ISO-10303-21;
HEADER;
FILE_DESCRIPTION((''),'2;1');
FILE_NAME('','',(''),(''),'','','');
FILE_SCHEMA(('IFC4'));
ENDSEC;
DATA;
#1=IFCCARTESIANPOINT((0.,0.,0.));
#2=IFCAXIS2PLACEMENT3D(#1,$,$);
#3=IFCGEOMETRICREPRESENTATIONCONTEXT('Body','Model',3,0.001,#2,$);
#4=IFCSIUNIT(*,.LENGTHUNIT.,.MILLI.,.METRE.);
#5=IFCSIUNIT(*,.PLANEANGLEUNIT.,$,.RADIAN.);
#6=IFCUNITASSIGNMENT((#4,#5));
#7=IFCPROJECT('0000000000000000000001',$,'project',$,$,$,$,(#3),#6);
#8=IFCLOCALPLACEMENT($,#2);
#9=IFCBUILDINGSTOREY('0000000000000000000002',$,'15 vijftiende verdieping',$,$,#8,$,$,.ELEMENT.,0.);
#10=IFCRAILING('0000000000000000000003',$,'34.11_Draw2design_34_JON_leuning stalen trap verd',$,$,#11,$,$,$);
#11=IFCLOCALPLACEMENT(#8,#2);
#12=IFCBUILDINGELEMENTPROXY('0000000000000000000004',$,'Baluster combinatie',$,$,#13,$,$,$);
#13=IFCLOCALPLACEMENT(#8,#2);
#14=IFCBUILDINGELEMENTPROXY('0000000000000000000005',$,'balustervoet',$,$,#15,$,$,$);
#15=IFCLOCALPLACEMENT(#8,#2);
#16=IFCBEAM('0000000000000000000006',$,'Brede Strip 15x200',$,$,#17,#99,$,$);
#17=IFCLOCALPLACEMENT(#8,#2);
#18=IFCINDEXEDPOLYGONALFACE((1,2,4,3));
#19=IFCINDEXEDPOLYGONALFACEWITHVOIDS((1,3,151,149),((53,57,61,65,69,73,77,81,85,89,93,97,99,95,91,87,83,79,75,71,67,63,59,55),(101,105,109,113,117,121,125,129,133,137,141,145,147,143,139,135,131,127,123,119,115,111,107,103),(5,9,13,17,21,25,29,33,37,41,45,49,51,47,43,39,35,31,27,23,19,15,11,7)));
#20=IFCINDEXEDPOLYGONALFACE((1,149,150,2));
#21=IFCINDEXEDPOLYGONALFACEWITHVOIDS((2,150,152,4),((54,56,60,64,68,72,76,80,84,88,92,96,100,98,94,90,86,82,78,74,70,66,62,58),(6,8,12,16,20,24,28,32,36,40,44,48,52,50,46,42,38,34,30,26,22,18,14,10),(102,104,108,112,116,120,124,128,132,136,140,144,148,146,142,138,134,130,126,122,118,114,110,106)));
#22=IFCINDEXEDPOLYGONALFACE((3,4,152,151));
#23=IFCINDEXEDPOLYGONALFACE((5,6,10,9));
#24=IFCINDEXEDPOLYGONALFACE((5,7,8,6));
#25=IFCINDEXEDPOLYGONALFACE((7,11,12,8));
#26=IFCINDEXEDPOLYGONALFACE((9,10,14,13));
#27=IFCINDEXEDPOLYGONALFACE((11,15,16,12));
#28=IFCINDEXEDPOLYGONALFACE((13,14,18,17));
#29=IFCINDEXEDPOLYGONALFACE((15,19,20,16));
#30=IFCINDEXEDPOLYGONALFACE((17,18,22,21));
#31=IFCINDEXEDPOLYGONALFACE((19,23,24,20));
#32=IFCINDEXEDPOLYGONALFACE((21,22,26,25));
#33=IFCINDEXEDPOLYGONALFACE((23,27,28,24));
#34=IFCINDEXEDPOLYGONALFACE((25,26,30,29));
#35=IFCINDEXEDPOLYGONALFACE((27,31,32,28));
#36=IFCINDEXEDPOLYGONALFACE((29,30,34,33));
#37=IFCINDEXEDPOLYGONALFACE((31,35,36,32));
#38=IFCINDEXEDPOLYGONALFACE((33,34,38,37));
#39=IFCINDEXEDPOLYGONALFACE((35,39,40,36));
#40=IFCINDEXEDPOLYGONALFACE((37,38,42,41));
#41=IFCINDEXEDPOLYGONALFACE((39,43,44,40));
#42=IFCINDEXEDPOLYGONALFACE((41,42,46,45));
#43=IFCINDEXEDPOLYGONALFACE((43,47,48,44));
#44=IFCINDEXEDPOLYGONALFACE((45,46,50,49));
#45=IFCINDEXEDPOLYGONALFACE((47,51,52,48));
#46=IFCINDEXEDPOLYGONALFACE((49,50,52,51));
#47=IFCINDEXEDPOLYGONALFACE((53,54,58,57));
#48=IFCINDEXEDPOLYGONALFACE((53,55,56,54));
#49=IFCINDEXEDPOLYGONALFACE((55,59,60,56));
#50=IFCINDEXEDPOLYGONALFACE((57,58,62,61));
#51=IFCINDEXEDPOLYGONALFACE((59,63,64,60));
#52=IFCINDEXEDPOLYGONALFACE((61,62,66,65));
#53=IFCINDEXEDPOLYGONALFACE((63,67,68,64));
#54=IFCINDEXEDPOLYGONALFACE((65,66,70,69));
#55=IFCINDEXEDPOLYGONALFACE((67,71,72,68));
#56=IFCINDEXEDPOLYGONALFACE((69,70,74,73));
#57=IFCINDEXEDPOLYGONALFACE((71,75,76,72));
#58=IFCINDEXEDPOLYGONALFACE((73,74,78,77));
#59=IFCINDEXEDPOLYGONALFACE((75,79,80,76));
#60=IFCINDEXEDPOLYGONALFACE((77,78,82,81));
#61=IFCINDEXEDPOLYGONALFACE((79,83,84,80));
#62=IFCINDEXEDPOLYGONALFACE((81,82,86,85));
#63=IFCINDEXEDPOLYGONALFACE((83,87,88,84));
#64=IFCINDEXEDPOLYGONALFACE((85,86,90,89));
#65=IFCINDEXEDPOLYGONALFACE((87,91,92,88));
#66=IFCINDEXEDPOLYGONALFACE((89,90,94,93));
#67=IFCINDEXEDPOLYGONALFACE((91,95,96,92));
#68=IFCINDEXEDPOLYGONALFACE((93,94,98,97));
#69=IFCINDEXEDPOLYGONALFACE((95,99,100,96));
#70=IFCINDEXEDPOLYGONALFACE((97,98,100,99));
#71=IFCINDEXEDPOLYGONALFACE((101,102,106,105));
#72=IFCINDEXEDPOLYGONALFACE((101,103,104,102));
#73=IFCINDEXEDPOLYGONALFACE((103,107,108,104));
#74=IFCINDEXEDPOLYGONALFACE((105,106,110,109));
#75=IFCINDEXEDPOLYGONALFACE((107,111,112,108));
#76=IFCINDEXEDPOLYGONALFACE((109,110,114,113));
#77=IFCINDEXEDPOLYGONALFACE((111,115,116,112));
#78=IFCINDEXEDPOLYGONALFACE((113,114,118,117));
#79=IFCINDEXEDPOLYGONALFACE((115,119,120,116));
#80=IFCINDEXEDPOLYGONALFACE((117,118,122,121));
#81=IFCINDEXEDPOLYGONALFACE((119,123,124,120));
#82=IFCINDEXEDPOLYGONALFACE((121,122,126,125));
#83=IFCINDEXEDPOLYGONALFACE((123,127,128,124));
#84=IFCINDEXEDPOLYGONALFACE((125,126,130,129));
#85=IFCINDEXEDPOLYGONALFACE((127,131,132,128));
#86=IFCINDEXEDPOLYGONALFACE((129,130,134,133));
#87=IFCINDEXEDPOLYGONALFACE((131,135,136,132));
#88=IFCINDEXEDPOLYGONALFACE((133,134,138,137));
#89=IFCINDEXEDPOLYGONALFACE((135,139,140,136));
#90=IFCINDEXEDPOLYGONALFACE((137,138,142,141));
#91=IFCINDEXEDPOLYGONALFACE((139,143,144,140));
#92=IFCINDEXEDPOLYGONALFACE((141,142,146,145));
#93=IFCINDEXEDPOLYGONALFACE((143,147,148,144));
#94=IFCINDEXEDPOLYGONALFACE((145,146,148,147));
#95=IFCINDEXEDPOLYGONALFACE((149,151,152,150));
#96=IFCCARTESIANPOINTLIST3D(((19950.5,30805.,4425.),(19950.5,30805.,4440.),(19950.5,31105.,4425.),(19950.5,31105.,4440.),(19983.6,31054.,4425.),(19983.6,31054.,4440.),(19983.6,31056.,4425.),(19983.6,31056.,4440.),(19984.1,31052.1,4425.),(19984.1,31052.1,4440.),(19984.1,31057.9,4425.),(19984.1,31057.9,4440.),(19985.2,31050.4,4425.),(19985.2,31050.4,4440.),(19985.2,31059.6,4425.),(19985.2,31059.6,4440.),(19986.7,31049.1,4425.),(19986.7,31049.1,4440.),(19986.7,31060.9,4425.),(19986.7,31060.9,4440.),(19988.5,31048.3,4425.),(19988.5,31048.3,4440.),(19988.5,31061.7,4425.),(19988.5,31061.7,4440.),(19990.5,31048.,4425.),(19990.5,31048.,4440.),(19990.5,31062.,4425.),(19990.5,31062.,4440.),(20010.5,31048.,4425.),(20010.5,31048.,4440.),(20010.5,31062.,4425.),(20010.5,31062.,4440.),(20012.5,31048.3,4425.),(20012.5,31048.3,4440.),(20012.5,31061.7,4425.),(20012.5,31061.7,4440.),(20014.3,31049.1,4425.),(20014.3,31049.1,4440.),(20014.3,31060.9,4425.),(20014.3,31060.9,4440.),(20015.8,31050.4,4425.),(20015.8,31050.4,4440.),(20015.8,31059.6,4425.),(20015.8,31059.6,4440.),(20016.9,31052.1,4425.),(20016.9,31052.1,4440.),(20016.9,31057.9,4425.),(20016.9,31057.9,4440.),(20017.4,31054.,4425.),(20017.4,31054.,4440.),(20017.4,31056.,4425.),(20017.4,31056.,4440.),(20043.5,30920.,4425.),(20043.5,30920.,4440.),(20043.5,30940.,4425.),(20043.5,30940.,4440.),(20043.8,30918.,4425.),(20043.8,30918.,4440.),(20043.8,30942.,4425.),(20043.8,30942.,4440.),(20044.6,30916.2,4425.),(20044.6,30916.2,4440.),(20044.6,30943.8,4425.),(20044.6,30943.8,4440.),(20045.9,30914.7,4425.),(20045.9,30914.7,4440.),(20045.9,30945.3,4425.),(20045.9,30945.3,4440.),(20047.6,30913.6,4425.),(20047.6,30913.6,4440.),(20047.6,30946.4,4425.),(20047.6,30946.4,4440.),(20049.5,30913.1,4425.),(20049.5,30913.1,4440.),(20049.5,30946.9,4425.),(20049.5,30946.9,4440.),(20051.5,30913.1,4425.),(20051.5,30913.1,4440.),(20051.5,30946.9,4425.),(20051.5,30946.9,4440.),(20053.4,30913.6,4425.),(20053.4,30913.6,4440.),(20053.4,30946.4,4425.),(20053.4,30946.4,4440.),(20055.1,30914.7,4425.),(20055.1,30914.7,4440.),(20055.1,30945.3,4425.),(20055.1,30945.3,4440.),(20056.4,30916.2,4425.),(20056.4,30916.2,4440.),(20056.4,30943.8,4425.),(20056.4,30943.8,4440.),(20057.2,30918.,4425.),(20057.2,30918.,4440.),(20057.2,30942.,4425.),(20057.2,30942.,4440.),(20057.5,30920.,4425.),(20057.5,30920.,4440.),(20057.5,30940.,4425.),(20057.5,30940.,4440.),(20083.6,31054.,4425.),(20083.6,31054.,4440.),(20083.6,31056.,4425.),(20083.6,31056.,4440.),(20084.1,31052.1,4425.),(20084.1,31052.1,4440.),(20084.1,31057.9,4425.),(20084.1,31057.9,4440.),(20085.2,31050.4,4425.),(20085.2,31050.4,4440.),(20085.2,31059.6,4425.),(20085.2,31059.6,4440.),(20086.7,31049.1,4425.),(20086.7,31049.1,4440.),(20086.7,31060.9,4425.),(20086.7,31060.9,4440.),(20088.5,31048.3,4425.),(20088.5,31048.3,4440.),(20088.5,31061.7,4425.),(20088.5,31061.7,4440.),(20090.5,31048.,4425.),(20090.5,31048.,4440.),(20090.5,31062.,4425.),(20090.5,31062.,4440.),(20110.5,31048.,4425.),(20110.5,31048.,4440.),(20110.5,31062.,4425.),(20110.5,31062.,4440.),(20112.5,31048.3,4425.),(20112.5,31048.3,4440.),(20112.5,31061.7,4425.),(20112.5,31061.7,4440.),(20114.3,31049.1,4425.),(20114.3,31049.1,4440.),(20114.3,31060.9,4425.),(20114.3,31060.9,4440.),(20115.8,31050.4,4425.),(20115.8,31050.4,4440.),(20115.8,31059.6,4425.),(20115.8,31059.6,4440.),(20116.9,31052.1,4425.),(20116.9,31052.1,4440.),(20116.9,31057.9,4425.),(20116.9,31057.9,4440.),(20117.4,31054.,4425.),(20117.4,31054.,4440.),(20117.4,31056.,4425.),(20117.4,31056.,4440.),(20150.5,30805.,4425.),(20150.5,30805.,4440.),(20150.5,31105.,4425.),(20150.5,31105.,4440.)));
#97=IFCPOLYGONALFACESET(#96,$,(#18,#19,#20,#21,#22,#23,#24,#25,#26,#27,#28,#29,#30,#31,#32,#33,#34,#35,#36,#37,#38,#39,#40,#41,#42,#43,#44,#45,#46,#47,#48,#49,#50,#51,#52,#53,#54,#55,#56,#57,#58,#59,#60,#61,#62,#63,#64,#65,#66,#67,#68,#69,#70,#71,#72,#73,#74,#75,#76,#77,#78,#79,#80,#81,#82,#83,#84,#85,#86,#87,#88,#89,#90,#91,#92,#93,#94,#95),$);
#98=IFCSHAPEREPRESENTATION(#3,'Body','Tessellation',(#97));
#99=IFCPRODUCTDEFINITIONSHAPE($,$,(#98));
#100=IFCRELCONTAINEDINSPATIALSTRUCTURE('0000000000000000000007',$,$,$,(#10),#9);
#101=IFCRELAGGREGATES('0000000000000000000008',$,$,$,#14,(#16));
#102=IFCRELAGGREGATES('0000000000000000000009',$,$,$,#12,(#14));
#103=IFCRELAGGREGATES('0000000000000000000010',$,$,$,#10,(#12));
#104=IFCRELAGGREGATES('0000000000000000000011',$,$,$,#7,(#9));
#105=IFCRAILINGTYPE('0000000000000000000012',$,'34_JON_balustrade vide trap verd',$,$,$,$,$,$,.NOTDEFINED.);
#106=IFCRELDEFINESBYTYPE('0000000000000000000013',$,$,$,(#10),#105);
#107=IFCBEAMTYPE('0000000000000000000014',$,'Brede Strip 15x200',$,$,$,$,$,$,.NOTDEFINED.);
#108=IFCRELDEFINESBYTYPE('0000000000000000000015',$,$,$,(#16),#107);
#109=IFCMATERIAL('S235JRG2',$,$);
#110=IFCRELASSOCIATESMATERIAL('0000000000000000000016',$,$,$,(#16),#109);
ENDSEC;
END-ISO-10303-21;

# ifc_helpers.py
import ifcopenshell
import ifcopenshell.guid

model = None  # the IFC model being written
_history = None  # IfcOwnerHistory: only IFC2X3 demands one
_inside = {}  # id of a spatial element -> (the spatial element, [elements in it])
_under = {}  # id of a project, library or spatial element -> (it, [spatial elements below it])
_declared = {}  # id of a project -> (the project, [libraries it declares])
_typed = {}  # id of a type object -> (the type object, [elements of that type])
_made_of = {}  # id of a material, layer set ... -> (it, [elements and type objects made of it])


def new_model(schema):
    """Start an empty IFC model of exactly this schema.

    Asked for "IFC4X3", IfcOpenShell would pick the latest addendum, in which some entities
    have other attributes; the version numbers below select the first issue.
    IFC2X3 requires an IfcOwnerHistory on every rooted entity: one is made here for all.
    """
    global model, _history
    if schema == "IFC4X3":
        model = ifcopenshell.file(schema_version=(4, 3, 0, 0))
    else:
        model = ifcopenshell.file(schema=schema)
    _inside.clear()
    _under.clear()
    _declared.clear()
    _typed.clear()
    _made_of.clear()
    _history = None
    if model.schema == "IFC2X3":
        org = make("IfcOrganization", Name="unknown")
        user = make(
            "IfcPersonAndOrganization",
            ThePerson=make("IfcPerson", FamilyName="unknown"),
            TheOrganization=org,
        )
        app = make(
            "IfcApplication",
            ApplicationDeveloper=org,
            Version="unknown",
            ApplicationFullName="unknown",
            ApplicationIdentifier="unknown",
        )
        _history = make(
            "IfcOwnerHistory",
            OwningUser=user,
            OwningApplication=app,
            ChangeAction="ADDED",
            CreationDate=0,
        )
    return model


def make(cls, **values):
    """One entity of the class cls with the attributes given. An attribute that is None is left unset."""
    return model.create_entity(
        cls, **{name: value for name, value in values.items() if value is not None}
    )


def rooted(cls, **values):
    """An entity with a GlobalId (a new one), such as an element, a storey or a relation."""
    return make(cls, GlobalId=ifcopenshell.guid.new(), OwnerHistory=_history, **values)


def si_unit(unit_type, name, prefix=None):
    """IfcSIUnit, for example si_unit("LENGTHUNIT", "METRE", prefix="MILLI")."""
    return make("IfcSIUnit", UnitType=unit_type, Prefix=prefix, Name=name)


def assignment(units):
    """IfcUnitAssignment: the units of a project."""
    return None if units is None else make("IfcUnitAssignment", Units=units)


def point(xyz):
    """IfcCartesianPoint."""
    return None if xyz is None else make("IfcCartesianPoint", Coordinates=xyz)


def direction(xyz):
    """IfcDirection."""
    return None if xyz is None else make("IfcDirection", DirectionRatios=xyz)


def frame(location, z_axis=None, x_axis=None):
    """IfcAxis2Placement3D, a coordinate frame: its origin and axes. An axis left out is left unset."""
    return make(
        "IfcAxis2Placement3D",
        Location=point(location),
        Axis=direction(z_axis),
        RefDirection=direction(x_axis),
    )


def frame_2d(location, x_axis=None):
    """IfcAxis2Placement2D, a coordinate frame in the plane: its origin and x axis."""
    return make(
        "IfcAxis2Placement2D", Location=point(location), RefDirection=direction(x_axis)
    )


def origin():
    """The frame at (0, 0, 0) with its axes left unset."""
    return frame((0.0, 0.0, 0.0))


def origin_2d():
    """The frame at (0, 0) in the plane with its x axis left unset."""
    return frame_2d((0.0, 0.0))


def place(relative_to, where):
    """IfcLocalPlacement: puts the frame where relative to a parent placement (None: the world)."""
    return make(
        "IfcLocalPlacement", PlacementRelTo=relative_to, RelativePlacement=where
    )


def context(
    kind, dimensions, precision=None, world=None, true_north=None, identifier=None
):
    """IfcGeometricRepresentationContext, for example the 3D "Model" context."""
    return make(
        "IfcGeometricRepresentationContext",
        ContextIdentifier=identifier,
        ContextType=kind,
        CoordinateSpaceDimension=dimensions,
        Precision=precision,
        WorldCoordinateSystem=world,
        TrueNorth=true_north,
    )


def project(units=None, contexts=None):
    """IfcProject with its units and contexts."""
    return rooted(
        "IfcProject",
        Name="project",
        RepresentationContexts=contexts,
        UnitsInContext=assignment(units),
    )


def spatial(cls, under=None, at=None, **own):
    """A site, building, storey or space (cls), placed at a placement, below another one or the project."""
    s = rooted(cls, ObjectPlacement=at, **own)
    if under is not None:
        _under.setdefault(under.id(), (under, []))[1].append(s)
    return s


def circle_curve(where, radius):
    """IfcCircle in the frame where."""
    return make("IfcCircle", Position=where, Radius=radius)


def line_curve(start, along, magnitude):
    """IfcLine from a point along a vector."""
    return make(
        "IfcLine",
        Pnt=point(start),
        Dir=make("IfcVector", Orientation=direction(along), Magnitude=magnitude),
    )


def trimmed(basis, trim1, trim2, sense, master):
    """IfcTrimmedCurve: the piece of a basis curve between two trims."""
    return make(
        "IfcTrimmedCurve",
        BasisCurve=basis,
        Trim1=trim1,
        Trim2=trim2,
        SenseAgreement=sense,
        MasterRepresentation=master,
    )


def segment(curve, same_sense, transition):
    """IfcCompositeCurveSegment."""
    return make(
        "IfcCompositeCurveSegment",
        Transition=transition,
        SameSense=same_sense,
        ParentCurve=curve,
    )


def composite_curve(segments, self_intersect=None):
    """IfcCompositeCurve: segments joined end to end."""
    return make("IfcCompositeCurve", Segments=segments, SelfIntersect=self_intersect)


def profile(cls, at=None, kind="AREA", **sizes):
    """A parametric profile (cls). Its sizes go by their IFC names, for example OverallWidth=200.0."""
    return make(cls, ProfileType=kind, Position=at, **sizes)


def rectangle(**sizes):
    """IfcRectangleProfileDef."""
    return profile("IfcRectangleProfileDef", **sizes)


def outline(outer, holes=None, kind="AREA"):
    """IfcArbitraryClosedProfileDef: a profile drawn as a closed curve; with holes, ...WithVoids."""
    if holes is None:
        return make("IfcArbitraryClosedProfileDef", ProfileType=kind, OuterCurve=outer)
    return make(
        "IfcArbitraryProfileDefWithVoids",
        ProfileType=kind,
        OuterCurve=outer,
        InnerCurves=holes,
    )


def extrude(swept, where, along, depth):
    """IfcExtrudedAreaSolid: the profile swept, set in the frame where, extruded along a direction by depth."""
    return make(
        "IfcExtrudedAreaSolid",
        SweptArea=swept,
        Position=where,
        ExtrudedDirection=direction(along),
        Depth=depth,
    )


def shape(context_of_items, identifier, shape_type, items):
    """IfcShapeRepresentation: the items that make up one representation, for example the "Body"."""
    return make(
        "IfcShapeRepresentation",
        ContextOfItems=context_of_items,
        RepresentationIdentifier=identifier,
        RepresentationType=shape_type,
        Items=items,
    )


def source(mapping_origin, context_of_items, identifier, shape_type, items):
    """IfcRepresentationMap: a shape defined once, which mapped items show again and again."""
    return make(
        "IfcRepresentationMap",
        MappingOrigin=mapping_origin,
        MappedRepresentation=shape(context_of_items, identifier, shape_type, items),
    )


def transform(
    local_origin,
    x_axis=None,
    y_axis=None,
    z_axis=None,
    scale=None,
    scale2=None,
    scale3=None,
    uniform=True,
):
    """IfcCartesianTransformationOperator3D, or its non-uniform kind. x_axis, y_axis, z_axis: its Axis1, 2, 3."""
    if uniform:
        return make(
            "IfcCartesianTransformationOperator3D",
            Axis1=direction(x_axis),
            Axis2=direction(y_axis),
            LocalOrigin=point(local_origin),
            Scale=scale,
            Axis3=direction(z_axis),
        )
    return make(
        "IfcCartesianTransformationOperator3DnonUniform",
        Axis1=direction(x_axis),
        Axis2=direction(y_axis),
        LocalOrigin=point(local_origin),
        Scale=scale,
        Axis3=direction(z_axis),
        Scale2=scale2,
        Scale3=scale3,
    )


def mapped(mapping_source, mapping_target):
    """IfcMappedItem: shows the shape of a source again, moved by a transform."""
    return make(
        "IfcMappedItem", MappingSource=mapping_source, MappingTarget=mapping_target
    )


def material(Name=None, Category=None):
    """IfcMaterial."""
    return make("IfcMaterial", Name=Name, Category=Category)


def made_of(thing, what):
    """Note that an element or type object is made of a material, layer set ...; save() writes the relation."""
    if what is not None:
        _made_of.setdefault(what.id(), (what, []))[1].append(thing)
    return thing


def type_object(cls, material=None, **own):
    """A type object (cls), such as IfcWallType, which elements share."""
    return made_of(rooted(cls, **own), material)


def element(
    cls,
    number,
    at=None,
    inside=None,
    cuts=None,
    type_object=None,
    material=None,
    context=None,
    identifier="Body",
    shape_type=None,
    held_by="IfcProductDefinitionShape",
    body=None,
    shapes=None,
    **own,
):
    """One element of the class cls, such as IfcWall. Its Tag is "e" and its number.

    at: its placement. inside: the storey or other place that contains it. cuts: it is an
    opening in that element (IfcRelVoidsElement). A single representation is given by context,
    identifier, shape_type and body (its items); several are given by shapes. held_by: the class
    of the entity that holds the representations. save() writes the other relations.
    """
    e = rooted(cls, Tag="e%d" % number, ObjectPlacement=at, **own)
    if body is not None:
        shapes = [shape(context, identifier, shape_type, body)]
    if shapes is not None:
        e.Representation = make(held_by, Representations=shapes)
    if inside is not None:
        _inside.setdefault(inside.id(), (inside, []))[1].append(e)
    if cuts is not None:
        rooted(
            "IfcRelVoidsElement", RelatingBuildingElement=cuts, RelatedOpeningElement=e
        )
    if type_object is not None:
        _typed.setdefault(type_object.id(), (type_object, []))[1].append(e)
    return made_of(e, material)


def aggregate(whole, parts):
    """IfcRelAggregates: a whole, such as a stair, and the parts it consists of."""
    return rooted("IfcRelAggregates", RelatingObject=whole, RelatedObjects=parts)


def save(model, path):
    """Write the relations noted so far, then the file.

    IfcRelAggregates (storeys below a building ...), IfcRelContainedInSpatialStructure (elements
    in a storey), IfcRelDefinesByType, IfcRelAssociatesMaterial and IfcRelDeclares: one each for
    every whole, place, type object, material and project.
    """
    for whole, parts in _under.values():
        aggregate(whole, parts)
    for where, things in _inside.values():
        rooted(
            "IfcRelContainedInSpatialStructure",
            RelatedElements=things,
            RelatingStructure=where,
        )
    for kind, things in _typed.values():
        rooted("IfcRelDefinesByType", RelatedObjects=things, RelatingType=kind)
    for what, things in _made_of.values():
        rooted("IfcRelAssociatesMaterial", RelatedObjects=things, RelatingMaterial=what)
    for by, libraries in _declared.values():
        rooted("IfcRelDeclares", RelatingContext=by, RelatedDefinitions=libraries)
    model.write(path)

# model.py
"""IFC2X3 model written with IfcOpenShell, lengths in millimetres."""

from ifc_helpers import new_model, si_unit, point, frame, frame_2d, origin, origin_2d, place, context, project, spatial, circle_curve, line_curve, trimmed, segment, composite_curve, rectangle, outline, extrude, source, transform, mapped, material, type_object, element, aggregate, save


model = new_model("IFC2X3")

# Units and contexts
model_context = context("Model", 3, precision=0.001, world=origin(), identifier="Body")
ifc_project = project(units=[si_unit("LENGTHUNIT", "METRE", prefix="MILLI"), si_unit("PLANEANGLEUNIT", "RADIAN")], contexts=[model_context])

# Storey
storey_placement = place(None, origin())
storey = spatial("IfcBuildingStorey", under=ifc_project, at=storey_placement, Name="15 vijftiende verdieping", CompositionType="ELEMENT", Elevation=0.0)

# Railing, building element proxies, beam, openings
railing_type = type_object("IfcRailingType", Name="34_JON_balustrade vide trap verd")
railing_placement = place(storey_placement, frame((-24393.0, 51609.5, -44800.0), z_axis=(0.0, 0.0, 1.0), x_axis=(0.0, -1.0, 0.0)))
railing = element("IfcRailing", 1, at=railing_placement, inside=storey, type_object=railing_type, Name="34.11_Draw2design_34_JON_leuning stalen trap verd")
proxy_1_placement = place(railing_placement, frame((20504.5, 45027.5, 49235.0), z_axis=(0.0, 0.0, 1.0), x_axis=(0.0, -1.0, 0.0)))
proxy_1 = element("IfcBuildingElementProxy", 2, at=proxy_1_placement, Name="Baluster combinatie")
ifc_material_1 = material(Name="S235JRG2")
proxy_2_placement = place(proxy_1_placement, frame((-44323.0, 21054.5, -49235.0), z_axis=(0.0, 0.0, 1.0), x_axis=(0.0, -1.0, 0.0)))
proxy_2 = element("IfcBuildingElementProxy", 3, at=proxy_2_placement, Name="balustervoet")
beam_type_1 = type_object("IfcBeamType", Name="Brede Strip 15x200")
shared_shape_1 = source(origin(), model_context, "Body", "SweptSolid", [
    extrude(rectangle(XDim=15.0, YDim=200.0, at=origin_2d()), origin(), (0.0, 0.0, -1.0), 300.0),
])
beam_1_placement = place(proxy_2_placement, frame((21054.5, 44907.0, 49232.5), z_axis=(1.0, 0.0, 0.0), x_axis=(0.0, 0.0, 1.0)))
beam_1 = element("IfcBeam", 4, at=beam_1_placement, type_object=beam_type_1, material=ifc_material_1, Name="Brede Strip 15x200", context=model_context, shape_type="MappedRepresentation", body=[
    mapped(shared_shape_1, transform((0.0, 0.0, 0.0), scale=1.0)),
])
opening_1_placement = place(beam_1_placement, frame((7.5, 0.0, -175.0), z_axis=(-1.0, 0.0, 0.0), x_axis=(0.0, 0.0, -1.0)))
element("IfcOpeningElement", 5, at=opening_1_placement, cuts=beam_1, ObjectType="Opening", context=model_context, shape_type="SweptSolid", body=[
    extrude(outline(composite_curve([segment(trimmed(circle_curve(frame_2d((10.0, 0.0), x_axis=(0.0, -1.0)), 7.0), [point((10.0, 7.0))], [point((10.0, -7.0))], False, "CARTESIAN"), True, "CONTINUOUS"), segment(trimmed(line_curve((10.0, -7.0), (-20.0, 0.0), 20.0), [point((10.0, -7.0))], [point((-10.0, -7.0))], True, "CARTESIAN"), True, "CONTINUOUS"), segment(trimmed(circle_curve(frame_2d((-10.0, 0.0), x_axis=(0.0, -1.0)), 7.0), [point((-10.0, -7.0))], [point((-10.0, 7.0))], False, "CARTESIAN"), True, "CONTINUOUS"), segment(trimmed(line_curve((-10.0, 7.0), (20.0, 0.0), 20.0), [point((-10.0, 7.0))], [point((10.0, 7.0))], True, "CARTESIAN"), True, "CONTINUOUS")], self_intersect=False)), origin(), (0.0, 0.0, 1.0), 15.0),
])
opening_2_placement = place(beam_1_placement, frame((7.5, -50.0, -50.0), z_axis=(-1.0, 0.0, 0.0), x_axis=(0.0, -1.0, 0.0)))
element("IfcOpeningElement", 6, at=opening_2_placement, cuts=beam_1, ObjectType="Opening", context=model_context, shape_type="SweptSolid", body=[
    extrude(outline(composite_curve([segment(trimmed(circle_curve(frame_2d((10.0, 0.0), x_axis=(0.0, -1.0)), 7.0), [point((10.0, 7.0))], [point((10.0, -7.0))], False, "CARTESIAN"), True, "CONTINUOUS"), segment(trimmed(line_curve((10.0, -7.0), (-20.0, 0.0), 20.0), [point((10.0, -7.0))], [point((-10.0, -7.0))], True, "CARTESIAN"), True, "CONTINUOUS"), segment(trimmed(circle_curve(frame_2d((-10.0, 0.0), x_axis=(0.0, -1.0)), 7.0), [point((-10.0, -7.0))], [point((-10.0, 7.0))], False, "CARTESIAN"), True, "CONTINUOUS"), segment(trimmed(line_curve((-10.0, 7.0), (20.0, 0.0), 20.0), [point((-10.0, 7.0))], [point((10.0, 7.0))], True, "CARTESIAN"), True, "CONTINUOUS")], self_intersect=False)), origin(), (0.0, 0.0, 1.0), 15.0),
])
opening_3_placement = place(beam_1_placement, frame((7.5, 50.0, -50.0), z_axis=(-1.0, 0.0, 0.0), x_axis=(0.0, -1.0, 0.0)))
element("IfcOpeningElement", 7, at=opening_3_placement, cuts=beam_1, ObjectType="Opening", context=model_context, shape_type="SweptSolid", body=[
    extrude(outline(composite_curve([segment(trimmed(circle_curve(frame_2d((10.0, 0.0), x_axis=(0.0, -1.0)), 7.0), [point((10.0, 7.0))], [point((10.0, -7.0))], False, "CARTESIAN"), True, "CONTINUOUS"), segment(trimmed(line_curve((10.0, -7.0), (-20.0, 0.0), 20.0), [point((10.0, -7.0))], [point((-10.0, -7.0))], True, "CARTESIAN"), True, "CONTINUOUS"), segment(trimmed(circle_curve(frame_2d((-10.0, 0.0), x_axis=(0.0, -1.0)), 7.0), [point((-10.0, -7.0))], [point((-10.0, 7.0))], False, "CARTESIAN"), True, "CONTINUOUS"), segment(trimmed(line_curve((-10.0, 7.0), (20.0, 0.0), 20.0), [point((-10.0, 7.0))], [point((10.0, 7.0))], True, "CARTESIAN"), True, "CONTINUOUS")], self_intersect=False)), origin(), (0.0, 0.0, 1.0), 15.0),
])
aggregate(proxy_2, [beam_1])
aggregate(proxy_1, [proxy_2])
aggregate(railing, [proxy_1])

save(model, "model.ifc")
